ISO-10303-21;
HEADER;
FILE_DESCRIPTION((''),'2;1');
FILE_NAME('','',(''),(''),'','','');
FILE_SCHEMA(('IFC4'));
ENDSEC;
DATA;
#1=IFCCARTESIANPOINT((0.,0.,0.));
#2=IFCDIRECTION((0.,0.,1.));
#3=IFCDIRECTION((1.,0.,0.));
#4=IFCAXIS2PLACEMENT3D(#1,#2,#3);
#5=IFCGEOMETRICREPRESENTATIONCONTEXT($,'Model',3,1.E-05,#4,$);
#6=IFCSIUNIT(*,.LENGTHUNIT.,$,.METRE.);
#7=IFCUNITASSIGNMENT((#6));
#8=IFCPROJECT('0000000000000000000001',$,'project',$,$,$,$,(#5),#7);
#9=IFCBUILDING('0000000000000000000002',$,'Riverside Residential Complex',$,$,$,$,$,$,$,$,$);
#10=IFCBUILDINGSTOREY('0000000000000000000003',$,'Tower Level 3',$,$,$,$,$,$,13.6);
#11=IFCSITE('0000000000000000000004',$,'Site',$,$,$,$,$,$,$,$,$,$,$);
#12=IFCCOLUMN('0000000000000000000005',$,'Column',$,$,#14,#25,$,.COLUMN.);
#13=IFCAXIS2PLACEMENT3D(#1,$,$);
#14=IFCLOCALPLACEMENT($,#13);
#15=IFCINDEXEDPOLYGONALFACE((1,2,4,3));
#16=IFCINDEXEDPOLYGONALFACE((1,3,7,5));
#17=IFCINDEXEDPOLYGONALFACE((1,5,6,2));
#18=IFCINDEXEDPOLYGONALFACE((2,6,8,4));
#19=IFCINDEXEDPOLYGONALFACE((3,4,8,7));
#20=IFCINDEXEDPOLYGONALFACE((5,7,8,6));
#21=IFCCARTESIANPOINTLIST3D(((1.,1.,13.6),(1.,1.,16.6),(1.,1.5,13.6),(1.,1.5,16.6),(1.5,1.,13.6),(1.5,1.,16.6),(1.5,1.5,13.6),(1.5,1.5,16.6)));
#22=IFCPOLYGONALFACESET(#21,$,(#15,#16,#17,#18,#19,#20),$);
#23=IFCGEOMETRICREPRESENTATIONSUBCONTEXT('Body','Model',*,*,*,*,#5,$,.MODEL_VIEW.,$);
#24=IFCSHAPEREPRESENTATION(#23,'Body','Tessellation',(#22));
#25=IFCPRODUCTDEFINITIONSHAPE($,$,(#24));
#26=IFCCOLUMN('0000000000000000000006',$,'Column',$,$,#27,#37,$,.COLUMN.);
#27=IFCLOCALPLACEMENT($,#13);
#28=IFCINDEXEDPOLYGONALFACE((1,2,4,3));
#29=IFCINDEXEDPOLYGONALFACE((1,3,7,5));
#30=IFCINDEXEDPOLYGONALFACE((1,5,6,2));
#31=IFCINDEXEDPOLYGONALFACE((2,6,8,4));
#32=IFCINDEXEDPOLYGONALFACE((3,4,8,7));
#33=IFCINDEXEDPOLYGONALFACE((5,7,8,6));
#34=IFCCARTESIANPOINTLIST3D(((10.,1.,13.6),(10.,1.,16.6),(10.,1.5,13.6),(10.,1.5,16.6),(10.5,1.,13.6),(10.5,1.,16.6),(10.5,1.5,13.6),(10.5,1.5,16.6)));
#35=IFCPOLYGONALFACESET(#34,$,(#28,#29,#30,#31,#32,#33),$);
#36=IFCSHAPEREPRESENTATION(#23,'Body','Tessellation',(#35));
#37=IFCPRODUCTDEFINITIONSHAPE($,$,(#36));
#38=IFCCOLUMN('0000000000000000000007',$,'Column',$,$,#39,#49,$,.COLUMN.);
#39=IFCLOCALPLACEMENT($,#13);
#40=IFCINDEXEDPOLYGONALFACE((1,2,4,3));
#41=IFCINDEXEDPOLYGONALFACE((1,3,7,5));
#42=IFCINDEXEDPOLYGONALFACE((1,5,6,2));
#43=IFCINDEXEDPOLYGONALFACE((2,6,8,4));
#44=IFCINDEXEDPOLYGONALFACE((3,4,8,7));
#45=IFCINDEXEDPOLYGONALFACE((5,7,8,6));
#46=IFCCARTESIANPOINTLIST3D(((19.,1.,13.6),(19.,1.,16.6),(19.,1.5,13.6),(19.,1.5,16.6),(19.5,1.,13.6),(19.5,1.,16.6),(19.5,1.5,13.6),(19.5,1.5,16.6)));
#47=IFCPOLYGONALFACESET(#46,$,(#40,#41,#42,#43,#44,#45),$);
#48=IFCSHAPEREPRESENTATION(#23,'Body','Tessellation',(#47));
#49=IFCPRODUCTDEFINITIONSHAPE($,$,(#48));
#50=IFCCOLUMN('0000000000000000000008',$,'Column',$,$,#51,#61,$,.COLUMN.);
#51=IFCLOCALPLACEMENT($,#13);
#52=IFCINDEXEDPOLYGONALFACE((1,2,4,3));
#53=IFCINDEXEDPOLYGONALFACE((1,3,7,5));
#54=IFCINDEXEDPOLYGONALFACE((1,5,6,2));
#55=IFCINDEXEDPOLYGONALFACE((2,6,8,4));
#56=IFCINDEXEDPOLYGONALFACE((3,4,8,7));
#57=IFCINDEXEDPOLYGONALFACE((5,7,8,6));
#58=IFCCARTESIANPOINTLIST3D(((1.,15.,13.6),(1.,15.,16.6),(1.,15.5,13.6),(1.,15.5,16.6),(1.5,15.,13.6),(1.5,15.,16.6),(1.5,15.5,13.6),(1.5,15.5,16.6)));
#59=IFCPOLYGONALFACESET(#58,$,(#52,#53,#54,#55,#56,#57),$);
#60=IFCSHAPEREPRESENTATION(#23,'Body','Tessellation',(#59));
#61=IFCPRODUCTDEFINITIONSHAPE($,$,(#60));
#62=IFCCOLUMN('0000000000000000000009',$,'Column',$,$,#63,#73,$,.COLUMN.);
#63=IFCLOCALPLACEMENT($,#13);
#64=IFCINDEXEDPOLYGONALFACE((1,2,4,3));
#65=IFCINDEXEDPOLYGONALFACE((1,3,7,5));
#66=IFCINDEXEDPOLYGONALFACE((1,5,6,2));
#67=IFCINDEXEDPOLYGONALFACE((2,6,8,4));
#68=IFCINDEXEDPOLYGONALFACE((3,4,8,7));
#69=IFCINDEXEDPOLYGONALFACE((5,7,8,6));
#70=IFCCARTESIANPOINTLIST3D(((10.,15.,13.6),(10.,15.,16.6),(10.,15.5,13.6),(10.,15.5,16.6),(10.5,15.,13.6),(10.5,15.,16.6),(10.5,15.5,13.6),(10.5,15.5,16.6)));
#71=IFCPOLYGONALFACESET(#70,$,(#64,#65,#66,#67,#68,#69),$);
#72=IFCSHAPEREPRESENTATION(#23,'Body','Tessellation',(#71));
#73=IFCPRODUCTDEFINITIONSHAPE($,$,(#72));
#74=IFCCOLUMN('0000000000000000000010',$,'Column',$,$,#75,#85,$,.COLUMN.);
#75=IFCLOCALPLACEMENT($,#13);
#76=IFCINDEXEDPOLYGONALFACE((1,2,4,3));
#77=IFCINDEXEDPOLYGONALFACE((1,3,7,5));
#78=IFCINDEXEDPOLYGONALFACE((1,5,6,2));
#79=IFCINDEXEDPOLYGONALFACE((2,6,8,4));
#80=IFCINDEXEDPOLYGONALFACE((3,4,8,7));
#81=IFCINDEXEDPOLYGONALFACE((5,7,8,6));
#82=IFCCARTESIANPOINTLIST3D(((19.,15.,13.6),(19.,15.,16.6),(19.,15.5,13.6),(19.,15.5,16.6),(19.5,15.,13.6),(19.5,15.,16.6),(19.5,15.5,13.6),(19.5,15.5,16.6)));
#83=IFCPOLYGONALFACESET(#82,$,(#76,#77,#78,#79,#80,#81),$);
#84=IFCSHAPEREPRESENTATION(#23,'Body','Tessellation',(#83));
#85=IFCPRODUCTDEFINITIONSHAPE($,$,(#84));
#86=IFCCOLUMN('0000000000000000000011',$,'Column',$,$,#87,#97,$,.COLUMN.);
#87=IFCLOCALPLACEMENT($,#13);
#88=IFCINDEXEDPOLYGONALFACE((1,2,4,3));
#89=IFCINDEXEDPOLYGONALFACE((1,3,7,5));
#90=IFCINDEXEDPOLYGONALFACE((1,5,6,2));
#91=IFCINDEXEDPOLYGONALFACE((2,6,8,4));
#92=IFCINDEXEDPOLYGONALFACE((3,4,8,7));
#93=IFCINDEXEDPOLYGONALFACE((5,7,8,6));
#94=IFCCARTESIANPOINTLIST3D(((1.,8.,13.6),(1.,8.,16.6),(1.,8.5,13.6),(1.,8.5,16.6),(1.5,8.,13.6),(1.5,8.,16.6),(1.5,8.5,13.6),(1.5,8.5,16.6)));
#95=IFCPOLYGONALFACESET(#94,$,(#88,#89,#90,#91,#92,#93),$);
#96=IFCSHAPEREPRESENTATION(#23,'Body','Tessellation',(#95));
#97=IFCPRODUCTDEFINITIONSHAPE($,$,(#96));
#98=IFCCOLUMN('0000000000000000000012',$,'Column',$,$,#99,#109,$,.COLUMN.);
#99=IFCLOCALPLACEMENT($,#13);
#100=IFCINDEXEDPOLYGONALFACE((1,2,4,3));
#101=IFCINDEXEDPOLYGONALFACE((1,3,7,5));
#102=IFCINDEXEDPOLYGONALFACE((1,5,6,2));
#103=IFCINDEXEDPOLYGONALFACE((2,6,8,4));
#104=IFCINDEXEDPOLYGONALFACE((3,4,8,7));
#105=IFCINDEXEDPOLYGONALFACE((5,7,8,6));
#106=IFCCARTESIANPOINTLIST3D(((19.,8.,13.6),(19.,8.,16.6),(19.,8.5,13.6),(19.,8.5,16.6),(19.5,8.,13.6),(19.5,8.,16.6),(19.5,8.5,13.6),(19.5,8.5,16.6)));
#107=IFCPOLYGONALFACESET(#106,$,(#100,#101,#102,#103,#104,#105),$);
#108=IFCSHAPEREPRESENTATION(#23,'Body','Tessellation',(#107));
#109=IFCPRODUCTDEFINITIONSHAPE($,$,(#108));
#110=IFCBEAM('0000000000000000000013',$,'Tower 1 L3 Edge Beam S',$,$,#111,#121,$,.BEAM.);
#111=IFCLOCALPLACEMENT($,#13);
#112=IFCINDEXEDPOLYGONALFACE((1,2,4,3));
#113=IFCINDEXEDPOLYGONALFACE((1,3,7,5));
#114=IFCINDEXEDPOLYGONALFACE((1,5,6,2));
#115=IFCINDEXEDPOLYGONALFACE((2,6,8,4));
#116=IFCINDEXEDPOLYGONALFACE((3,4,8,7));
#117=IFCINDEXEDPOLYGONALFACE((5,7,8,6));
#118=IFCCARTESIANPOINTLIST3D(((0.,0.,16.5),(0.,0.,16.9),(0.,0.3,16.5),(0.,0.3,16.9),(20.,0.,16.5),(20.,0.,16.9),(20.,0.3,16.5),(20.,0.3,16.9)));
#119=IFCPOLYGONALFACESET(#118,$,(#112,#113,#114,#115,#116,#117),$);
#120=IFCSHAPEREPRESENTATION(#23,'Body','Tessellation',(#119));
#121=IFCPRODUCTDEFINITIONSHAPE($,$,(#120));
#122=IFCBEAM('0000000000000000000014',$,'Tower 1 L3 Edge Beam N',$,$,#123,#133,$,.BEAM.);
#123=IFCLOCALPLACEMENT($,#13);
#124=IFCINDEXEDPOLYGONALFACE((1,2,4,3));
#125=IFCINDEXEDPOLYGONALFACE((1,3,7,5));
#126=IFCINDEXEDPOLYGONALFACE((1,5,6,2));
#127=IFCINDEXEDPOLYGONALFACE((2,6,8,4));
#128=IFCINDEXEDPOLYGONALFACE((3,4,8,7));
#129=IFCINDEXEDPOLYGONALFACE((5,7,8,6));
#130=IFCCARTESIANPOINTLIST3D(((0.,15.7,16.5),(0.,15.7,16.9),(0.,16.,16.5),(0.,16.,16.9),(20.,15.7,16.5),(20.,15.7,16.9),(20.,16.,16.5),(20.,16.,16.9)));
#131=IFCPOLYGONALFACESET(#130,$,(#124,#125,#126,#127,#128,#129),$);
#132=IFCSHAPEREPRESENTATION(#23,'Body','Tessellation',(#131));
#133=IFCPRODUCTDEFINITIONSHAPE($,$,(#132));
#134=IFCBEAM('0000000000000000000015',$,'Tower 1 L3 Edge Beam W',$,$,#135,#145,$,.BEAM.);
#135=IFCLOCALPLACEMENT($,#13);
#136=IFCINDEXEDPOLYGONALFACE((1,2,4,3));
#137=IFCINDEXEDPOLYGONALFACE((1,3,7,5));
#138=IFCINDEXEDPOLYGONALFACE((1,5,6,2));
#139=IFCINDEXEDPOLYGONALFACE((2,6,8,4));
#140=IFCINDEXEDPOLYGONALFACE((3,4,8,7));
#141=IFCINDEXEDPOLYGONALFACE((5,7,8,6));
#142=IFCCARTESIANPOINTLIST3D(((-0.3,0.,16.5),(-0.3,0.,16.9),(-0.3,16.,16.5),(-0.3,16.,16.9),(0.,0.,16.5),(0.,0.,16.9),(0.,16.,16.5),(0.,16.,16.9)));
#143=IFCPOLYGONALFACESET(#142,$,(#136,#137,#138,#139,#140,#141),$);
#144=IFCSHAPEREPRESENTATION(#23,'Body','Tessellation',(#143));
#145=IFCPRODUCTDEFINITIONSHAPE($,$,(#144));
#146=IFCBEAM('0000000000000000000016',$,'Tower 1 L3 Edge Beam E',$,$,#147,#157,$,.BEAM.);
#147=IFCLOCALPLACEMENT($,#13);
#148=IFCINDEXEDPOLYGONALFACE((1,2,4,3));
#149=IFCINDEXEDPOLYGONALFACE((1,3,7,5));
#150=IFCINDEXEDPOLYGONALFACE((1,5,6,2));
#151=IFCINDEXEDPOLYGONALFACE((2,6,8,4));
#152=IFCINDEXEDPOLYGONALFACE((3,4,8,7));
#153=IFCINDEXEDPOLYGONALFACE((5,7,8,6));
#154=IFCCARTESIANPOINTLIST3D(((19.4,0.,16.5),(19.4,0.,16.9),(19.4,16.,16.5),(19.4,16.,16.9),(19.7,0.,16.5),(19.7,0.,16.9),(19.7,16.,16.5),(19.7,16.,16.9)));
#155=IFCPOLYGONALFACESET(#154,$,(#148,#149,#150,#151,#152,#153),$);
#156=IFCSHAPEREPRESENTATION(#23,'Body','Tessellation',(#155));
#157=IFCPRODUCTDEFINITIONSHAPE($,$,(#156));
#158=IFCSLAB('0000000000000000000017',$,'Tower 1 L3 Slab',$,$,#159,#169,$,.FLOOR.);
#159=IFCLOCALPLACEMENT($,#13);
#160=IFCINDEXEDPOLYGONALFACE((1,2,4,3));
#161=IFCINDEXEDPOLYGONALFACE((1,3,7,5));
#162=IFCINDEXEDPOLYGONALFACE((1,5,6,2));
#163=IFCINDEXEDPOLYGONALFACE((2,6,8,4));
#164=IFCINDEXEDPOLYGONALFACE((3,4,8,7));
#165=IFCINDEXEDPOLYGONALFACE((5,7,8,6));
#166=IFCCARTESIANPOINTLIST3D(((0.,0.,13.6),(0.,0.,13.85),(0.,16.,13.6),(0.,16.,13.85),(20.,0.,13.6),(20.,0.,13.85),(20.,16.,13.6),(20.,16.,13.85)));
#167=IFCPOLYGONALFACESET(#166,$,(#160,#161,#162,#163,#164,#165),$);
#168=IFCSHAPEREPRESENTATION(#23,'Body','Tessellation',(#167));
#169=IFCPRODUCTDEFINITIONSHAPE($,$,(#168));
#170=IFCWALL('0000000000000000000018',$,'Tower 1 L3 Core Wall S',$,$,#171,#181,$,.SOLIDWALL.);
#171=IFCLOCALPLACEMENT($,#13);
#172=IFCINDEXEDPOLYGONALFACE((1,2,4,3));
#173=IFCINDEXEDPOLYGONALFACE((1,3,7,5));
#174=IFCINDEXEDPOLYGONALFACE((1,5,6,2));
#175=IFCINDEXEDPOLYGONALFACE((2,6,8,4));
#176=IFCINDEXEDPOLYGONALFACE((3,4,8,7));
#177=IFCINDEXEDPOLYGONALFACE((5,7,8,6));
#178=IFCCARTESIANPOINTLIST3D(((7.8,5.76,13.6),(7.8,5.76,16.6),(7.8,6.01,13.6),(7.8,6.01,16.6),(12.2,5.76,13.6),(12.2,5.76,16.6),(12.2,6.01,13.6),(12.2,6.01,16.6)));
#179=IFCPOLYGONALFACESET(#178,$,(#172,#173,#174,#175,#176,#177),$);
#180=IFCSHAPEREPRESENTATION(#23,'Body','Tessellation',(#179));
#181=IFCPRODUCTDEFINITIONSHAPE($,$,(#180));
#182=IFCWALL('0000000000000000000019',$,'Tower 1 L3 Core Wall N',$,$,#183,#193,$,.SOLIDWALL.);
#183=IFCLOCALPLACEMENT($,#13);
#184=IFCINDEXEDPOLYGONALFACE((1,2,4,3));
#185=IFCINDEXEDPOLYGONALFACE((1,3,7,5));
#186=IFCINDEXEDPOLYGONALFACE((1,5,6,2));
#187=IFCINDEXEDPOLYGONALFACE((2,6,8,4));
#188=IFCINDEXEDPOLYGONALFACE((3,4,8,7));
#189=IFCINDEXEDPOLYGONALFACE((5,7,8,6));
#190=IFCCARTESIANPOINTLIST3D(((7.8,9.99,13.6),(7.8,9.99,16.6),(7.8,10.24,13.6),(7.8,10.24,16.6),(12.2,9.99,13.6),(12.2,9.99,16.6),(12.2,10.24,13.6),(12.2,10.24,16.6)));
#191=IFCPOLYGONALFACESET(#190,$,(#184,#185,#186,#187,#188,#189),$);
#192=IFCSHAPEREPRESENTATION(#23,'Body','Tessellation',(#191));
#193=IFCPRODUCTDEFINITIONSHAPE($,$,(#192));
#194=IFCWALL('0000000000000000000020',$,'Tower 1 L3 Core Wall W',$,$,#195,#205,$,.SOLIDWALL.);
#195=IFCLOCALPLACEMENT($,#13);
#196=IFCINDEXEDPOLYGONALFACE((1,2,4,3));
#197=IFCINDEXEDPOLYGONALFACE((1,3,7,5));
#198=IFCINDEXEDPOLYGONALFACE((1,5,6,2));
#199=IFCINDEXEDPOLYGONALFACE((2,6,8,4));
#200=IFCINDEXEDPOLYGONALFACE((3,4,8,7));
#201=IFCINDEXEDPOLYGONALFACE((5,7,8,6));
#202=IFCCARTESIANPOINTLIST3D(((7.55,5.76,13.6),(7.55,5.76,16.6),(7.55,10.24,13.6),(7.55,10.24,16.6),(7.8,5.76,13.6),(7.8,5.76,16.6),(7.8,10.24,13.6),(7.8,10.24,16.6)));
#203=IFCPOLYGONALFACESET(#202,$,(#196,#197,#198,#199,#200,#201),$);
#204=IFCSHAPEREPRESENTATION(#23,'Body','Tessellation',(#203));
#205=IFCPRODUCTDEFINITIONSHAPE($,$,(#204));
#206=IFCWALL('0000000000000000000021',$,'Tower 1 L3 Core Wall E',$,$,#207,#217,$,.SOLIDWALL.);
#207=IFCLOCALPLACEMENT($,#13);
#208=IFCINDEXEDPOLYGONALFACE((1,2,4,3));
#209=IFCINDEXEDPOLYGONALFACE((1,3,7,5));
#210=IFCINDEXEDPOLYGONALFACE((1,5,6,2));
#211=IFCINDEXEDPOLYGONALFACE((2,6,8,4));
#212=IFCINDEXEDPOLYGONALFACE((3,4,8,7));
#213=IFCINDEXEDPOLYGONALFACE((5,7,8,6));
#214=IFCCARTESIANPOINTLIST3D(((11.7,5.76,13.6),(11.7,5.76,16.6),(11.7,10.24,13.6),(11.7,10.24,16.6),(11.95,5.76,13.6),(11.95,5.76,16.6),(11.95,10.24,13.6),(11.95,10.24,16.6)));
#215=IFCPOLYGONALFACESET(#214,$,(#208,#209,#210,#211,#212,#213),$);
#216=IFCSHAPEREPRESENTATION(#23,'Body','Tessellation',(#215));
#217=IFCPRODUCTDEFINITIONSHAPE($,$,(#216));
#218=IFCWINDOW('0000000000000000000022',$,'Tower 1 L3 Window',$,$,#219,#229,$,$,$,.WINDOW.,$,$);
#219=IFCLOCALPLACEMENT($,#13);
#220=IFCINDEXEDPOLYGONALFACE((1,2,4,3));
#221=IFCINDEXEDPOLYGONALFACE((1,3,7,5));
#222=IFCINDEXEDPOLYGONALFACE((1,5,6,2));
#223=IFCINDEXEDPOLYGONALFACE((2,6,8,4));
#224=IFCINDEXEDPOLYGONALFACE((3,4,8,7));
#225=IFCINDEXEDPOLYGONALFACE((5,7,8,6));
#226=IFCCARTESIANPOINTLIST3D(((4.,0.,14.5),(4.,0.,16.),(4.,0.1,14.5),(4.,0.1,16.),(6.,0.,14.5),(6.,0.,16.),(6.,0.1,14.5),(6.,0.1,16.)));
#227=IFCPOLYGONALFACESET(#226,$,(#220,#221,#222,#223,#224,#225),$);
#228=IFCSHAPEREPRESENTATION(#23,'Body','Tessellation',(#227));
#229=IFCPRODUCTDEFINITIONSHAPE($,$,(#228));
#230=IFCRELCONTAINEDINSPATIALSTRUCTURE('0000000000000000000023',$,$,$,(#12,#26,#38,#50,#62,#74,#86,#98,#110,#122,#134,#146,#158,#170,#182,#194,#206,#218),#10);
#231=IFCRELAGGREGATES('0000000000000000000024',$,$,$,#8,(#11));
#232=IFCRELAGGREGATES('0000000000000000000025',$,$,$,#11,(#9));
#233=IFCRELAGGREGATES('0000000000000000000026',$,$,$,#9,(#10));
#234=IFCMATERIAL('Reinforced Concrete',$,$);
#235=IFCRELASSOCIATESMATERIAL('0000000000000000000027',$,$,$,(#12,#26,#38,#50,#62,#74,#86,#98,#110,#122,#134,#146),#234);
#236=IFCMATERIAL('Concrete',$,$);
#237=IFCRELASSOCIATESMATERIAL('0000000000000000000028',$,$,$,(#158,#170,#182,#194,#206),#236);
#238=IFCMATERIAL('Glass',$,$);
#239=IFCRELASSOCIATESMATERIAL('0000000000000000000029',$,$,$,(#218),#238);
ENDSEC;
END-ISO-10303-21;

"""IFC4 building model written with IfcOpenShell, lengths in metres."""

from ifc_helpers import new_model, si_unit, frame, origin_with_axes, place, context, subcontext, project, spatial, line, indexed_curve, outline, extrude, material, element, save


model = new_model("IFC4")

# Units and contexts
model_context = context("Model", 3, precision=1e-05, world=origin_with_axes())
body_context = subcontext(model_context, "Body", "Model", "MODEL_VIEW")
ifc_project = project(units=[si_unit("LENGTHUNIT", "METRE")], contexts=[model_context])

# Site, building, storey
site = spatial("IfcSite", under=ifc_project, Name="Site")
building = spatial("IfcBuilding", under=site, Name="Riverside Residential Complex")
storey = spatial("IfcBuildingStorey", under=building, Name="Tower Level 3", Elevation=13.6)

# Columns
ifc_material_1 = material(Name="Reinforced Concrete")
for number, where, z_axis, x_axis, name in (
    (1, (1.0, 1.0, 13.6), (0.0, 0.0, 1.0), (1.0, 0.0, 0.0), "Column"),
    (2, (10.0, 1.0, 13.6), (0.0, 0.0, 1.0), (1.0, 0.0, 0.0), "Column"),
    (3, (19.0, 1.0, 13.6), (0.0, 0.0, 1.0), (1.0, 0.0, 0.0), "Column"),
    (4, (1.0, 15.0, 13.6), (0.0, 0.0, 1.0), (1.0, 0.0, 0.0), "Column"),
    (5, (10.0, 15.0, 13.6), (0.0, 0.0, 1.0), (1.0, 0.0, 0.0), "Column"),
    (6, (19.0, 15.0, 13.6), (0.0, 0.0, 1.0), (1.0, 0.0, 0.0), "Column"),
    (7, (1.0, 8.0, 13.6), (0.0, 0.0, 1.0), (1.0, 0.0, 0.0), "Column"),
    (8, (19.0, 8.0, 13.6), (0.0, 0.0, 1.0), (1.0, 0.0, 0.0), "Column"),
):
    element("IfcColumn", number, at=place(None, frame(where, z_axis=z_axis, x_axis=x_axis)), inside=storey, material=ifc_material_1, Name=name, PredefinedType="COLUMN", context=body_context, shape_type="SweptSolid", body=[
        extrude(outline(indexed_curve([(0.0, 0.0), (0.5, 0.0), (0.5, 0.5), (0.0, 0.5)], segments=[line(1, 2, 3, 4, 1)])), origin_with_axes(), (0.0, 0.0, 1.0), 3.0),
    ])

# Beams
for number, where, z_axis, x_axis, name in (
    (9, (0.0, 0.0, 16.5), (0.0, 0.0, 1.0), (1.0, 0.0, 0.0), "Tower 1 L3 Edge Beam S"),
    (10, (0.0, 15.7, 16.5), (0.0, 0.0, 1.0), (1.0, 0.0, 0.0), "Tower 1 L3 Edge Beam N"),
):
    element("IfcBeam", number, at=place(None, frame(where, z_axis=z_axis, x_axis=x_axis)), inside=storey, material=ifc_material_1, Name=name, PredefinedType="BEAM", context=body_context, shape_type="SweptSolid", body=[
        extrude(outline(indexed_curve([(0.0, 0.0), (20.0, 0.0), (20.0, 0.3), (0.0, 0.3)], segments=[line(1, 2, 3, 4, 1)])), origin_with_axes(), (0.0, 0.0, 1.0), 0.4),
    ])
for number, where, z_axis, x_axis, name in (
    (11, (0.0, 0.0, 16.5), (0.0, 0.0, 1.0), (0.0, 1.0, 0.0), "Tower 1 L3 Edge Beam W"),
    (12, (19.7, 0.0, 16.5), (0.0, 0.0, 1.0), (0.0, 1.0, 0.0), "Tower 1 L3 Edge Beam E"),
):
    element("IfcBeam", number, at=place(None, frame(where, z_axis=z_axis, x_axis=x_axis)), inside=storey, material=ifc_material_1, Name=name, PredefinedType="BEAM", context=body_context, shape_type="SweptSolid", body=[
        extrude(outline(indexed_curve([(0.0, 0.0), (16.0, 0.0), (16.0, 0.3), (0.0, 0.3)], segments=[line(1, 2, 3, 4, 1)])), origin_with_axes(), (0.0, 0.0, 1.0), 0.4),
    ])

# Slab
ifc_material_2 = material(Name="Concrete")
slab_placement = place(None, frame((0.0, 0.0, 13.6), z_axis=(0.0, 0.0, 1.0), x_axis=(1.0, 0.0, 0.0)))
element("IfcSlab", 13, at=slab_placement, inside=storey, material=ifc_material_2, Name="Tower 1 L3 Slab", PredefinedType="FLOOR", context=body_context, shape_type="SweptSolid", body=[
    extrude(outline(indexed_curve([(0.0, 0.0), (20.0, 0.0), (20.0, 16.0), (0.0, 16.0)], segments=[line(1, 2, 3, 4, 1)])), origin_with_axes(), (0.0, 0.0, 1.0), 0.25),
])

# Walls
for number, where, z_axis, x_axis, name in (
    (14, (7.8, 5.76, 13.6), (0.0, 0.0, 1.0), (1.0, 0.0, 0.0), "Tower 1 L3 Core Wall S"),
    (15, (7.8, 9.99, 13.6), (0.0, 0.0, 1.0), (1.0, 0.0, 0.0), "Tower 1 L3 Core Wall N"),
):
    element("IfcWall", number, at=place(None, frame(where, z_axis=z_axis, x_axis=x_axis)), inside=storey, material=ifc_material_2, Name=name, PredefinedType="SOLIDWALL", context=body_context, shape_type="SweptSolid", body=[
        extrude(outline(indexed_curve([(0.0, 0.0), (4.4, 0.0), (4.4, 0.25), (0.0, 0.25)], segments=[line(1, 2, 3, 4, 1)])), origin_with_axes(), (0.0, 0.0, 1.0), 3.0),
    ])
for number, where, z_axis, x_axis, name in (
    (16, (7.8, 5.76, 13.6), (0.0, 0.0, 1.0), (0.0, 1.0, 0.0), "Tower 1 L3 Core Wall W"),
    (17, (11.95, 5.76, 13.6), (0.0, 0.0, 1.0), (0.0, 1.0, 0.0), "Tower 1 L3 Core Wall E"),
):
    element("IfcWall", number, at=place(None, frame(where, z_axis=z_axis, x_axis=x_axis)), inside=storey, material=ifc_material_2, Name=name, PredefinedType="SOLIDWALL", context=body_context, shape_type="SweptSolid", body=[
        extrude(outline(indexed_curve([(0.0, 0.0), (4.48, 0.0), (4.48, 0.25), (0.0, 0.25)], segments=[line(1, 2, 3, 4, 1)])), origin_with_axes(), (0.0, 0.0, 1.0), 3.0),
    ])

# Window
ifc_material_3 = material(Name="Glass")
for number, where, z_axis, x_axis, name in (
    (18, (4.0, 0.0, 14.5), (0.0, 0.0, 1.0), (1.0, 0.0, 0.0), "Tower 1 L3 Window"),
):
    element("IfcWindow", number, at=place(None, frame(where, z_axis=z_axis, x_axis=x_axis)), inside=storey, material=ifc_material_3, Name=name, PredefinedType="WINDOW", context=body_context, shape_type="SweptSolid", body=[
        extrude(outline(indexed_curve([(0.0, 0.0), (2.0, 0.0), (2.0, 0.1), (0.0, 0.1)], segments=[line(1, 2, 3, 4, 1)])), origin_with_axes(), (0.0, 0.0, 1.0), 1.5),
    ])

save(model, "model.ifc")
